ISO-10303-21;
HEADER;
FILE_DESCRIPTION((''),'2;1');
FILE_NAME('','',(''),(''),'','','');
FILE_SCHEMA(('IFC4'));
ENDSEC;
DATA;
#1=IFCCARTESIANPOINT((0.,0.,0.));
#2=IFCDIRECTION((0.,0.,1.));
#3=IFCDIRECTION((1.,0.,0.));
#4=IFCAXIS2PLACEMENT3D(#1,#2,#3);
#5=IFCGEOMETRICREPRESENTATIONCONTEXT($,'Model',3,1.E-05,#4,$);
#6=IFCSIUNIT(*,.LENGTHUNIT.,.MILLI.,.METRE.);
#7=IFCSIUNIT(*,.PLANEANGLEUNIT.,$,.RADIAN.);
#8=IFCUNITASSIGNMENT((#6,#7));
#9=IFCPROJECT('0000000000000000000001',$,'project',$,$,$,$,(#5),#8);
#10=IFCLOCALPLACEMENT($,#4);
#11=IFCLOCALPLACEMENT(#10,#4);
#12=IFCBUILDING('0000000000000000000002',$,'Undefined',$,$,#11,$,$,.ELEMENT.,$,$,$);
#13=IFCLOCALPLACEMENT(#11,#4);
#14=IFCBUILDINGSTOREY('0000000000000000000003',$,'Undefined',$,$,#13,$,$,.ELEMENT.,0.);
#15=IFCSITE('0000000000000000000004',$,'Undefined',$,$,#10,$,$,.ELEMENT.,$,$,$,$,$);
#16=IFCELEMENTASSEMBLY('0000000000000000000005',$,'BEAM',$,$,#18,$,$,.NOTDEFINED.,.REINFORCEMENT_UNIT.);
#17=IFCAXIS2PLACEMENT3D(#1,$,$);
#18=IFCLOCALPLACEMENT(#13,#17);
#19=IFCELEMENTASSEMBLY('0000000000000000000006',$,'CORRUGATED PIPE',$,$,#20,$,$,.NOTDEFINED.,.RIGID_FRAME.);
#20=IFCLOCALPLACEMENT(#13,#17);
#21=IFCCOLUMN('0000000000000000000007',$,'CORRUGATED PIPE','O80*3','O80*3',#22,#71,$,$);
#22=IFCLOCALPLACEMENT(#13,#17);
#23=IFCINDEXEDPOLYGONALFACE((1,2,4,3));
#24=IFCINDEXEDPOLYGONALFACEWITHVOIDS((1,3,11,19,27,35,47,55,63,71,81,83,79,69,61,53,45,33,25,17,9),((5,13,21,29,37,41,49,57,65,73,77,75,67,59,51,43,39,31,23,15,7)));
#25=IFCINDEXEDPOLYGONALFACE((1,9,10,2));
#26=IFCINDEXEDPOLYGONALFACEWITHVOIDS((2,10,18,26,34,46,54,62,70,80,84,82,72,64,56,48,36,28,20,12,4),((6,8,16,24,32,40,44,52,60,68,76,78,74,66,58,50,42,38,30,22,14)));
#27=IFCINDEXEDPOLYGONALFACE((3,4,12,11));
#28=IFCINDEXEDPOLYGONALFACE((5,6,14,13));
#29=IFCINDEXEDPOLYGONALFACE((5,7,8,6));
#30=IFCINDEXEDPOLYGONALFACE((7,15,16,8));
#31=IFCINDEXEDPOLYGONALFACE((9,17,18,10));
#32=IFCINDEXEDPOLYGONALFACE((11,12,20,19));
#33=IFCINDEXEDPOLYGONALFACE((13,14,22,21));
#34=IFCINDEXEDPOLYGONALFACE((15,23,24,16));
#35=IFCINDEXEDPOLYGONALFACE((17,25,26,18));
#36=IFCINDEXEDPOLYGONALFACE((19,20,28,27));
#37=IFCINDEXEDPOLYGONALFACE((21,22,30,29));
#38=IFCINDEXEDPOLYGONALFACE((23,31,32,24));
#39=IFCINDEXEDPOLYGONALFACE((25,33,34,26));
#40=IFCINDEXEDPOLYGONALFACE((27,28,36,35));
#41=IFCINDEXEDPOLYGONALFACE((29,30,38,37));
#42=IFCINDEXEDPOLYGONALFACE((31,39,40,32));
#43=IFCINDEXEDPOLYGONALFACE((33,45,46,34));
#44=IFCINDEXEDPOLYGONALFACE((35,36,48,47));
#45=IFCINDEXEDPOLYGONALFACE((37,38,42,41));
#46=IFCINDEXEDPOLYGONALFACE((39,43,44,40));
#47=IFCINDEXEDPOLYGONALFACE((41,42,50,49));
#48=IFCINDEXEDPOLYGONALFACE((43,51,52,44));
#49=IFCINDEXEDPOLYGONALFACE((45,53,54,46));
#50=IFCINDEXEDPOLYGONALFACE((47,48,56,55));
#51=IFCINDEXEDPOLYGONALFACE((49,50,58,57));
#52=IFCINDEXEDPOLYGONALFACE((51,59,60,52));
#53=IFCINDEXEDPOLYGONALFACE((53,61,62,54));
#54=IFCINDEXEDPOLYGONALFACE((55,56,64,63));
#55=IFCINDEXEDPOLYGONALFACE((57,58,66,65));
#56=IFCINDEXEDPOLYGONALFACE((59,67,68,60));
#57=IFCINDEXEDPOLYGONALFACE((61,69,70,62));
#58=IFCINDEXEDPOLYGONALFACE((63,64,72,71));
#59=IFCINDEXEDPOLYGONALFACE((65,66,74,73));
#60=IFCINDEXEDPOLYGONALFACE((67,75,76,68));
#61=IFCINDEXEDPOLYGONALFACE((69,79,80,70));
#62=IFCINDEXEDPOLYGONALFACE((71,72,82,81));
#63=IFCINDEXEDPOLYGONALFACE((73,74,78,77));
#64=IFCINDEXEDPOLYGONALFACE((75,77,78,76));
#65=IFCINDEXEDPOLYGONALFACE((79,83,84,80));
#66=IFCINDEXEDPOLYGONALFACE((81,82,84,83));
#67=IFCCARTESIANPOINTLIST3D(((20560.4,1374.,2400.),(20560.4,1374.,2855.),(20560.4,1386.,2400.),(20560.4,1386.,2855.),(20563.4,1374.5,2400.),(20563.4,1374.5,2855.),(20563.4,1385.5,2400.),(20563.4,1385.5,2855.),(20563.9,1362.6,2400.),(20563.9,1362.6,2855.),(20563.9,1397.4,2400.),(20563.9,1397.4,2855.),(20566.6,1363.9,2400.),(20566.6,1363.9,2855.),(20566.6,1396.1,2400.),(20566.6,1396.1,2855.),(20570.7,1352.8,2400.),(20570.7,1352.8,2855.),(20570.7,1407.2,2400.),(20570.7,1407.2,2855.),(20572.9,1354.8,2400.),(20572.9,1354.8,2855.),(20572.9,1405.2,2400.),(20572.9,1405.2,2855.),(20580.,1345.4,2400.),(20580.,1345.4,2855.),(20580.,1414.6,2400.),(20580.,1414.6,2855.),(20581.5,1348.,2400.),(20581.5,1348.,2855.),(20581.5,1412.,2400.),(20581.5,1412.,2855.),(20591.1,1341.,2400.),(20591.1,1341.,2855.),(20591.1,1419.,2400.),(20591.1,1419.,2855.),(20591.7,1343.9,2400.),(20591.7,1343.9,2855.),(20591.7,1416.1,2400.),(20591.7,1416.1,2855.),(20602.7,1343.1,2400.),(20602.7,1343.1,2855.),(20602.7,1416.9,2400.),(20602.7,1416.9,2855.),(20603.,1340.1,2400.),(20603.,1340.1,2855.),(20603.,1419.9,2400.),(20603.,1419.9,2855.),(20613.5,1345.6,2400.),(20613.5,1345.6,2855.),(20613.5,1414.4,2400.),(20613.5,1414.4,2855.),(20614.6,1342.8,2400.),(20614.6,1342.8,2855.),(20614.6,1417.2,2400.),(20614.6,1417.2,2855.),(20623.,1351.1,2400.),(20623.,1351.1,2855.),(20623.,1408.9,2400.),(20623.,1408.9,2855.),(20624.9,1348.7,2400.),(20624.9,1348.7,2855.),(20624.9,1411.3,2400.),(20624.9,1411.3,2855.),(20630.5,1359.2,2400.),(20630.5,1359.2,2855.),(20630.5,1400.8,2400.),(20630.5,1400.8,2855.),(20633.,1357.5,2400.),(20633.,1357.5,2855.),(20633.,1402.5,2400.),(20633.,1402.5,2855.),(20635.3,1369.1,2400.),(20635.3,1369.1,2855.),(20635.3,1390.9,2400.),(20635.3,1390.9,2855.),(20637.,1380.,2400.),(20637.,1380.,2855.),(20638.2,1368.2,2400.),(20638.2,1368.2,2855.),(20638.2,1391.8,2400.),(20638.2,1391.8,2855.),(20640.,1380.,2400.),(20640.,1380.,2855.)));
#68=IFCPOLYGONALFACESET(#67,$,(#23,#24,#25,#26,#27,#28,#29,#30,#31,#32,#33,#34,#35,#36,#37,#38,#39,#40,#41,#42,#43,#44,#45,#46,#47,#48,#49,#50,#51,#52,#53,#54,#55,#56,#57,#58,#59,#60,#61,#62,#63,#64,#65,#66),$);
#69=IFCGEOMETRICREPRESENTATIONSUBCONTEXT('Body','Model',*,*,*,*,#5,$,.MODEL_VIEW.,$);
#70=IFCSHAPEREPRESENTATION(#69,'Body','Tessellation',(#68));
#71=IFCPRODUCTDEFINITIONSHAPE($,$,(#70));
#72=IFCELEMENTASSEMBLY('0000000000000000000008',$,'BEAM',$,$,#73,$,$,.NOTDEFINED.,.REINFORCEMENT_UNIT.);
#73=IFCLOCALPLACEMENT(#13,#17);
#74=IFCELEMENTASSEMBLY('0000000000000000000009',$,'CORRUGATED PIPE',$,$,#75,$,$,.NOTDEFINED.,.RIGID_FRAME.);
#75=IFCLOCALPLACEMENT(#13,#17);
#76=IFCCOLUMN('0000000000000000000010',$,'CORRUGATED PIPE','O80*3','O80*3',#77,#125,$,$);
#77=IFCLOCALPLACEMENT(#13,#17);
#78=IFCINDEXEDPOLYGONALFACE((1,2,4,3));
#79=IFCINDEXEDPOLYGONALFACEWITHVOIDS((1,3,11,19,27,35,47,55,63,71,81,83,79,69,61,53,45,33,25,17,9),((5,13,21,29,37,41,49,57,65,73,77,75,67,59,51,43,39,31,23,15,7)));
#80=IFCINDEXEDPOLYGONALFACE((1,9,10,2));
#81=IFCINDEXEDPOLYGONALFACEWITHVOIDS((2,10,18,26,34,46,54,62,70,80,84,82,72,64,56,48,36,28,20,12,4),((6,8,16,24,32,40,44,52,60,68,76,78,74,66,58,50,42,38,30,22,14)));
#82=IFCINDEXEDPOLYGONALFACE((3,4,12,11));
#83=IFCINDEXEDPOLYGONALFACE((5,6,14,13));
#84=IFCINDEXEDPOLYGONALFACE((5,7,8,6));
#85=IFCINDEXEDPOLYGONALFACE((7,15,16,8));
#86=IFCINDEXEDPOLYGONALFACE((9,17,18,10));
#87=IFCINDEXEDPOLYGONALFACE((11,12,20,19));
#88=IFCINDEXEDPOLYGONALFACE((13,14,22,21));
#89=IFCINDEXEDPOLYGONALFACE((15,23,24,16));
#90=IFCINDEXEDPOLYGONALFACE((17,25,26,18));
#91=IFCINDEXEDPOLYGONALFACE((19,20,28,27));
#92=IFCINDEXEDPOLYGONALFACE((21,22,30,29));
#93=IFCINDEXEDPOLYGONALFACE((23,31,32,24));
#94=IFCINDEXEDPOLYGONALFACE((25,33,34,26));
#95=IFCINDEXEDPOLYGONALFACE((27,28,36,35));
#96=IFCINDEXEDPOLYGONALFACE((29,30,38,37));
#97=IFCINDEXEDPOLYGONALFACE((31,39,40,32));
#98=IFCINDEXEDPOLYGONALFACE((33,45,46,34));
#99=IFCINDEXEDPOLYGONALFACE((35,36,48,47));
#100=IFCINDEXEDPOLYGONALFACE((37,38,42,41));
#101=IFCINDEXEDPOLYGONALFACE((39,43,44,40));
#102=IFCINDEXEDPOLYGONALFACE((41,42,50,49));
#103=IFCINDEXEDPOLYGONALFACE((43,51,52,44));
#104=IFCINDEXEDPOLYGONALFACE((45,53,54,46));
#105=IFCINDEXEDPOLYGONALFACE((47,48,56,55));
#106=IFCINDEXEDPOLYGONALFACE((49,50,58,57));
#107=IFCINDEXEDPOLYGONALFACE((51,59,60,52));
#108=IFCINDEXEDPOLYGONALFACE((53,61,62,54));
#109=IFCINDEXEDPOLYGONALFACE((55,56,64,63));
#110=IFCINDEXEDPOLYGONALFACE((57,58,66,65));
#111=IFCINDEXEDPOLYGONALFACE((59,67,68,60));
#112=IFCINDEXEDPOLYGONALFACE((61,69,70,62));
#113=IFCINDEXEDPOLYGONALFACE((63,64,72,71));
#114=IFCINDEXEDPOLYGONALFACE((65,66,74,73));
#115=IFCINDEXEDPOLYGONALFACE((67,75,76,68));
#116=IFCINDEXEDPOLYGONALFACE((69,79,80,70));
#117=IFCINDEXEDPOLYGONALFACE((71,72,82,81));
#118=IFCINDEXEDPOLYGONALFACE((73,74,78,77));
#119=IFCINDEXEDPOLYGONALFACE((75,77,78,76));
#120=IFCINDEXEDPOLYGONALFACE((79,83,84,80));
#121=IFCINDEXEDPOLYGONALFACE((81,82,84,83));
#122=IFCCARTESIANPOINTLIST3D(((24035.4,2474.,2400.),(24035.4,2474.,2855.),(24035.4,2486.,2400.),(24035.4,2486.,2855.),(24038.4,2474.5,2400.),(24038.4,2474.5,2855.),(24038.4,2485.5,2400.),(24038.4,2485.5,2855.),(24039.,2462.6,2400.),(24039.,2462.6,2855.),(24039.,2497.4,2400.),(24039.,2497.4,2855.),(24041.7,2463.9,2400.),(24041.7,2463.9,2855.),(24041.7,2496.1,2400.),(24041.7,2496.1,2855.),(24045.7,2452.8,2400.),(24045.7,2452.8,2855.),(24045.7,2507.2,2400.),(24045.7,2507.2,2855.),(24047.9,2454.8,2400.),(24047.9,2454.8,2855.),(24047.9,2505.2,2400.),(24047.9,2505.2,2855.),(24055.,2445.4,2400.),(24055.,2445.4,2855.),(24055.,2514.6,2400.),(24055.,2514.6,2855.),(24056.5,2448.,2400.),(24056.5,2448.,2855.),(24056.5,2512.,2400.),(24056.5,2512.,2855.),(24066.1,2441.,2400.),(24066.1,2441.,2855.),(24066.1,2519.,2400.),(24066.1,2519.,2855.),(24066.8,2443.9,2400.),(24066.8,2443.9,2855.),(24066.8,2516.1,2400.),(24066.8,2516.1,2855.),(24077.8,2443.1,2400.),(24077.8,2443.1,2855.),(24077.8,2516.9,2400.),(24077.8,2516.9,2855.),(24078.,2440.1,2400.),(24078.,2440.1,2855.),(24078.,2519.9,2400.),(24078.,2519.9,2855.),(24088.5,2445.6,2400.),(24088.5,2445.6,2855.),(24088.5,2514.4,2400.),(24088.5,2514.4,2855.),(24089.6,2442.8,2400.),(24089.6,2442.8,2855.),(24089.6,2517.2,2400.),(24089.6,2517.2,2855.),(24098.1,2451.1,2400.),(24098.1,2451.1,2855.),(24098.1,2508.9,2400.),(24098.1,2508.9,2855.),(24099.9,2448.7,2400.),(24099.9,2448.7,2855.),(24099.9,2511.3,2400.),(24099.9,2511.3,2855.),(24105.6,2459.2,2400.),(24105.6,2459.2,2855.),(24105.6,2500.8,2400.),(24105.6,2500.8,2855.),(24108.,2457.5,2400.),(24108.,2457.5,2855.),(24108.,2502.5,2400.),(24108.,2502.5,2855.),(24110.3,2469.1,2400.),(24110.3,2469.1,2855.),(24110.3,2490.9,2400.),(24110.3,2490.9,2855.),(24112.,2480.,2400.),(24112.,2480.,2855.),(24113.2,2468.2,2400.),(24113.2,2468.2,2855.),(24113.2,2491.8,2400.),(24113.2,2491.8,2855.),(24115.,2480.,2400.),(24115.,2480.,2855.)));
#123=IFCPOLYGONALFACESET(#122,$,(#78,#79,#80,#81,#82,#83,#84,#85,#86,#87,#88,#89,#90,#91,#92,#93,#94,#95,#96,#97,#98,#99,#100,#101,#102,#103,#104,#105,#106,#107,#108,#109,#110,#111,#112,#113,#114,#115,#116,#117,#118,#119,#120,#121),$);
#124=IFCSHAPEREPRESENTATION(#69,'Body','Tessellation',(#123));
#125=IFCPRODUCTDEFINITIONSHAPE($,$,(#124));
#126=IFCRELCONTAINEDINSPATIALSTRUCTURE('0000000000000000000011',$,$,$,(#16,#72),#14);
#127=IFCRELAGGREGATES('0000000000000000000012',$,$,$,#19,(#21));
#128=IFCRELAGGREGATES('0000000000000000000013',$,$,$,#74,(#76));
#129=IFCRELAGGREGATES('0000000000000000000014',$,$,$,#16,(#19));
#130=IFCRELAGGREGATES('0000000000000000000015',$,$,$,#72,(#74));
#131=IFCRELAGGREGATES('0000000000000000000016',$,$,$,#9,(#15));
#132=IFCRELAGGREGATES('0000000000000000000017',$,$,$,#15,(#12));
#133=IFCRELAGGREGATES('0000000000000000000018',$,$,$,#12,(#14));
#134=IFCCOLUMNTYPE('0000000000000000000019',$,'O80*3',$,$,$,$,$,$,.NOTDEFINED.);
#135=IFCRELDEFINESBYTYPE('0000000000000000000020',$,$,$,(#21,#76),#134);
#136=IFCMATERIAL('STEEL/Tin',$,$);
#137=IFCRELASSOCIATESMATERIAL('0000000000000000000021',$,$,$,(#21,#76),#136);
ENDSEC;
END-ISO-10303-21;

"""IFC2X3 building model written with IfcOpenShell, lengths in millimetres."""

from ifc_helpers import new_model, si_unit, frame, origin_with_axes, origin_2d_with_axis, place, context, subcontext, project, spatial, hollow_circle, extrude, material, type_object, element, aggregate, save


model = new_model("IFC2X3")

# Units and contexts
model_context = context("Model", 3, precision=1e-05, world=origin_with_axes())
body_context = subcontext(model_context, "Body", "Model", "MODEL_VIEW")
ifc_project = project(units=[si_unit("LENGTHUNIT", "METRE", prefix="MILLI"), si_unit("PLANEANGLEUNIT", "RADIAN")], contexts=[model_context])

# Site, building, storey
site_placement = place(None, origin_with_axes())
site = spatial("IfcSite", under=ifc_project, at=site_placement, Name="Undefined", CompositionType="ELEMENT")
building_placement = place(site_placement, origin_with_axes())
building = spatial("IfcBuilding", under=site, at=building_placement, Name="Undefined", CompositionType="ELEMENT")
storey_placement = place(building_placement, origin_with_axes())
storey = spatial("IfcBuildingStorey", under=building, at=storey_placement, Name="Undefined", CompositionType="ELEMENT", Elevation=0.0)

# Element assemblies, column
assembly_1_placement = place(storey_placement, origin_with_axes())
assembly_1 = element("IfcElementAssembly", 1, at=assembly_1_placement, inside=storey, Name="BEAM", AssemblyPlace="NOTDEFINED", PredefinedType="REINFORCEMENT_UNIT")
assembly_2_placement = place(assembly_1_placement, origin_with_axes())
assembly_2 = element("IfcElementAssembly", 2, at=assembly_2_placement, Name="CORRUGATED PIPE", AssemblyPlace="NOTDEFINED", PredefinedType="RIGID_FRAME")
ifc_material_1 = material(Name="STEEL/Tin")
column_type = type_object("IfcColumnType", Name="O80*3", PredefinedType="NOTDEFINED")
column_1_placement = place(assembly_2_placement, frame((20600.0, 1380.0, 2400.0), z_axis=(0.0, 0.0, 1.0), x_axis=(0.0, -1.0, 0.0)))
column_1 = element("IfcColumn", 3, at=column_1_placement, type_object=column_type, material=ifc_material_1, Name="CORRUGATED PIPE", Description="O80*3", ObjectType="O80*3", context=body_context, shape_type="SweptSolid", body=[
    extrude(hollow_circle(Radius=40.0, WallThickness=3.0, at=origin_2d_with_axis()), frame((0.0, 0.0, 455.0), z_axis=(0.0, 0.0, -1.0), x_axis=(0.0, 1.0, 0.0)), (0.0, 0.0, 1.0), 455.0),
])
aggregate(assembly_2, [column_1])

# Element assemblies, column
assembly_3_placement = place(storey_placement, origin_with_axes())
assembly_3 = element("IfcElementAssembly", 4, at=assembly_3_placement, inside=storey, Name="BEAM", AssemblyPlace="NOTDEFINED", PredefinedType="REINFORCEMENT_UNIT")
assembly_4_placement = place(assembly_3_placement, origin_with_axes())
assembly_4 = element("IfcElementAssembly", 5, at=assembly_4_placement, Name="CORRUGATED PIPE", AssemblyPlace="NOTDEFINED", PredefinedType="RIGID_FRAME")
column_2_placement = place(assembly_4_placement, frame((24075.0, 2480.0, 2400.0), z_axis=(0.0, 0.0, 1.0), x_axis=(0.0, -1.0, 0.0)))
column_2 = element("IfcColumn", 6, at=column_2_placement, type_object=column_type, material=ifc_material_1, Name="CORRUGATED PIPE", Description="O80*3", ObjectType="O80*3", context=body_context, shape_type="SweptSolid", body=[
    extrude(hollow_circle(Radius=40.0, WallThickness=3.0, at=origin_2d_with_axis()), frame((0.0, 0.0, 455.0), z_axis=(0.0, 0.0, -1.0), x_axis=(0.0, 1.0, 0.0)), (0.0, 0.0, 1.0), 455.0),
])
aggregate(assembly_4, [column_2])

aggregate(assembly_1, [assembly_2])
aggregate(assembly_3, [assembly_4])

save(model, "model.ifc")
